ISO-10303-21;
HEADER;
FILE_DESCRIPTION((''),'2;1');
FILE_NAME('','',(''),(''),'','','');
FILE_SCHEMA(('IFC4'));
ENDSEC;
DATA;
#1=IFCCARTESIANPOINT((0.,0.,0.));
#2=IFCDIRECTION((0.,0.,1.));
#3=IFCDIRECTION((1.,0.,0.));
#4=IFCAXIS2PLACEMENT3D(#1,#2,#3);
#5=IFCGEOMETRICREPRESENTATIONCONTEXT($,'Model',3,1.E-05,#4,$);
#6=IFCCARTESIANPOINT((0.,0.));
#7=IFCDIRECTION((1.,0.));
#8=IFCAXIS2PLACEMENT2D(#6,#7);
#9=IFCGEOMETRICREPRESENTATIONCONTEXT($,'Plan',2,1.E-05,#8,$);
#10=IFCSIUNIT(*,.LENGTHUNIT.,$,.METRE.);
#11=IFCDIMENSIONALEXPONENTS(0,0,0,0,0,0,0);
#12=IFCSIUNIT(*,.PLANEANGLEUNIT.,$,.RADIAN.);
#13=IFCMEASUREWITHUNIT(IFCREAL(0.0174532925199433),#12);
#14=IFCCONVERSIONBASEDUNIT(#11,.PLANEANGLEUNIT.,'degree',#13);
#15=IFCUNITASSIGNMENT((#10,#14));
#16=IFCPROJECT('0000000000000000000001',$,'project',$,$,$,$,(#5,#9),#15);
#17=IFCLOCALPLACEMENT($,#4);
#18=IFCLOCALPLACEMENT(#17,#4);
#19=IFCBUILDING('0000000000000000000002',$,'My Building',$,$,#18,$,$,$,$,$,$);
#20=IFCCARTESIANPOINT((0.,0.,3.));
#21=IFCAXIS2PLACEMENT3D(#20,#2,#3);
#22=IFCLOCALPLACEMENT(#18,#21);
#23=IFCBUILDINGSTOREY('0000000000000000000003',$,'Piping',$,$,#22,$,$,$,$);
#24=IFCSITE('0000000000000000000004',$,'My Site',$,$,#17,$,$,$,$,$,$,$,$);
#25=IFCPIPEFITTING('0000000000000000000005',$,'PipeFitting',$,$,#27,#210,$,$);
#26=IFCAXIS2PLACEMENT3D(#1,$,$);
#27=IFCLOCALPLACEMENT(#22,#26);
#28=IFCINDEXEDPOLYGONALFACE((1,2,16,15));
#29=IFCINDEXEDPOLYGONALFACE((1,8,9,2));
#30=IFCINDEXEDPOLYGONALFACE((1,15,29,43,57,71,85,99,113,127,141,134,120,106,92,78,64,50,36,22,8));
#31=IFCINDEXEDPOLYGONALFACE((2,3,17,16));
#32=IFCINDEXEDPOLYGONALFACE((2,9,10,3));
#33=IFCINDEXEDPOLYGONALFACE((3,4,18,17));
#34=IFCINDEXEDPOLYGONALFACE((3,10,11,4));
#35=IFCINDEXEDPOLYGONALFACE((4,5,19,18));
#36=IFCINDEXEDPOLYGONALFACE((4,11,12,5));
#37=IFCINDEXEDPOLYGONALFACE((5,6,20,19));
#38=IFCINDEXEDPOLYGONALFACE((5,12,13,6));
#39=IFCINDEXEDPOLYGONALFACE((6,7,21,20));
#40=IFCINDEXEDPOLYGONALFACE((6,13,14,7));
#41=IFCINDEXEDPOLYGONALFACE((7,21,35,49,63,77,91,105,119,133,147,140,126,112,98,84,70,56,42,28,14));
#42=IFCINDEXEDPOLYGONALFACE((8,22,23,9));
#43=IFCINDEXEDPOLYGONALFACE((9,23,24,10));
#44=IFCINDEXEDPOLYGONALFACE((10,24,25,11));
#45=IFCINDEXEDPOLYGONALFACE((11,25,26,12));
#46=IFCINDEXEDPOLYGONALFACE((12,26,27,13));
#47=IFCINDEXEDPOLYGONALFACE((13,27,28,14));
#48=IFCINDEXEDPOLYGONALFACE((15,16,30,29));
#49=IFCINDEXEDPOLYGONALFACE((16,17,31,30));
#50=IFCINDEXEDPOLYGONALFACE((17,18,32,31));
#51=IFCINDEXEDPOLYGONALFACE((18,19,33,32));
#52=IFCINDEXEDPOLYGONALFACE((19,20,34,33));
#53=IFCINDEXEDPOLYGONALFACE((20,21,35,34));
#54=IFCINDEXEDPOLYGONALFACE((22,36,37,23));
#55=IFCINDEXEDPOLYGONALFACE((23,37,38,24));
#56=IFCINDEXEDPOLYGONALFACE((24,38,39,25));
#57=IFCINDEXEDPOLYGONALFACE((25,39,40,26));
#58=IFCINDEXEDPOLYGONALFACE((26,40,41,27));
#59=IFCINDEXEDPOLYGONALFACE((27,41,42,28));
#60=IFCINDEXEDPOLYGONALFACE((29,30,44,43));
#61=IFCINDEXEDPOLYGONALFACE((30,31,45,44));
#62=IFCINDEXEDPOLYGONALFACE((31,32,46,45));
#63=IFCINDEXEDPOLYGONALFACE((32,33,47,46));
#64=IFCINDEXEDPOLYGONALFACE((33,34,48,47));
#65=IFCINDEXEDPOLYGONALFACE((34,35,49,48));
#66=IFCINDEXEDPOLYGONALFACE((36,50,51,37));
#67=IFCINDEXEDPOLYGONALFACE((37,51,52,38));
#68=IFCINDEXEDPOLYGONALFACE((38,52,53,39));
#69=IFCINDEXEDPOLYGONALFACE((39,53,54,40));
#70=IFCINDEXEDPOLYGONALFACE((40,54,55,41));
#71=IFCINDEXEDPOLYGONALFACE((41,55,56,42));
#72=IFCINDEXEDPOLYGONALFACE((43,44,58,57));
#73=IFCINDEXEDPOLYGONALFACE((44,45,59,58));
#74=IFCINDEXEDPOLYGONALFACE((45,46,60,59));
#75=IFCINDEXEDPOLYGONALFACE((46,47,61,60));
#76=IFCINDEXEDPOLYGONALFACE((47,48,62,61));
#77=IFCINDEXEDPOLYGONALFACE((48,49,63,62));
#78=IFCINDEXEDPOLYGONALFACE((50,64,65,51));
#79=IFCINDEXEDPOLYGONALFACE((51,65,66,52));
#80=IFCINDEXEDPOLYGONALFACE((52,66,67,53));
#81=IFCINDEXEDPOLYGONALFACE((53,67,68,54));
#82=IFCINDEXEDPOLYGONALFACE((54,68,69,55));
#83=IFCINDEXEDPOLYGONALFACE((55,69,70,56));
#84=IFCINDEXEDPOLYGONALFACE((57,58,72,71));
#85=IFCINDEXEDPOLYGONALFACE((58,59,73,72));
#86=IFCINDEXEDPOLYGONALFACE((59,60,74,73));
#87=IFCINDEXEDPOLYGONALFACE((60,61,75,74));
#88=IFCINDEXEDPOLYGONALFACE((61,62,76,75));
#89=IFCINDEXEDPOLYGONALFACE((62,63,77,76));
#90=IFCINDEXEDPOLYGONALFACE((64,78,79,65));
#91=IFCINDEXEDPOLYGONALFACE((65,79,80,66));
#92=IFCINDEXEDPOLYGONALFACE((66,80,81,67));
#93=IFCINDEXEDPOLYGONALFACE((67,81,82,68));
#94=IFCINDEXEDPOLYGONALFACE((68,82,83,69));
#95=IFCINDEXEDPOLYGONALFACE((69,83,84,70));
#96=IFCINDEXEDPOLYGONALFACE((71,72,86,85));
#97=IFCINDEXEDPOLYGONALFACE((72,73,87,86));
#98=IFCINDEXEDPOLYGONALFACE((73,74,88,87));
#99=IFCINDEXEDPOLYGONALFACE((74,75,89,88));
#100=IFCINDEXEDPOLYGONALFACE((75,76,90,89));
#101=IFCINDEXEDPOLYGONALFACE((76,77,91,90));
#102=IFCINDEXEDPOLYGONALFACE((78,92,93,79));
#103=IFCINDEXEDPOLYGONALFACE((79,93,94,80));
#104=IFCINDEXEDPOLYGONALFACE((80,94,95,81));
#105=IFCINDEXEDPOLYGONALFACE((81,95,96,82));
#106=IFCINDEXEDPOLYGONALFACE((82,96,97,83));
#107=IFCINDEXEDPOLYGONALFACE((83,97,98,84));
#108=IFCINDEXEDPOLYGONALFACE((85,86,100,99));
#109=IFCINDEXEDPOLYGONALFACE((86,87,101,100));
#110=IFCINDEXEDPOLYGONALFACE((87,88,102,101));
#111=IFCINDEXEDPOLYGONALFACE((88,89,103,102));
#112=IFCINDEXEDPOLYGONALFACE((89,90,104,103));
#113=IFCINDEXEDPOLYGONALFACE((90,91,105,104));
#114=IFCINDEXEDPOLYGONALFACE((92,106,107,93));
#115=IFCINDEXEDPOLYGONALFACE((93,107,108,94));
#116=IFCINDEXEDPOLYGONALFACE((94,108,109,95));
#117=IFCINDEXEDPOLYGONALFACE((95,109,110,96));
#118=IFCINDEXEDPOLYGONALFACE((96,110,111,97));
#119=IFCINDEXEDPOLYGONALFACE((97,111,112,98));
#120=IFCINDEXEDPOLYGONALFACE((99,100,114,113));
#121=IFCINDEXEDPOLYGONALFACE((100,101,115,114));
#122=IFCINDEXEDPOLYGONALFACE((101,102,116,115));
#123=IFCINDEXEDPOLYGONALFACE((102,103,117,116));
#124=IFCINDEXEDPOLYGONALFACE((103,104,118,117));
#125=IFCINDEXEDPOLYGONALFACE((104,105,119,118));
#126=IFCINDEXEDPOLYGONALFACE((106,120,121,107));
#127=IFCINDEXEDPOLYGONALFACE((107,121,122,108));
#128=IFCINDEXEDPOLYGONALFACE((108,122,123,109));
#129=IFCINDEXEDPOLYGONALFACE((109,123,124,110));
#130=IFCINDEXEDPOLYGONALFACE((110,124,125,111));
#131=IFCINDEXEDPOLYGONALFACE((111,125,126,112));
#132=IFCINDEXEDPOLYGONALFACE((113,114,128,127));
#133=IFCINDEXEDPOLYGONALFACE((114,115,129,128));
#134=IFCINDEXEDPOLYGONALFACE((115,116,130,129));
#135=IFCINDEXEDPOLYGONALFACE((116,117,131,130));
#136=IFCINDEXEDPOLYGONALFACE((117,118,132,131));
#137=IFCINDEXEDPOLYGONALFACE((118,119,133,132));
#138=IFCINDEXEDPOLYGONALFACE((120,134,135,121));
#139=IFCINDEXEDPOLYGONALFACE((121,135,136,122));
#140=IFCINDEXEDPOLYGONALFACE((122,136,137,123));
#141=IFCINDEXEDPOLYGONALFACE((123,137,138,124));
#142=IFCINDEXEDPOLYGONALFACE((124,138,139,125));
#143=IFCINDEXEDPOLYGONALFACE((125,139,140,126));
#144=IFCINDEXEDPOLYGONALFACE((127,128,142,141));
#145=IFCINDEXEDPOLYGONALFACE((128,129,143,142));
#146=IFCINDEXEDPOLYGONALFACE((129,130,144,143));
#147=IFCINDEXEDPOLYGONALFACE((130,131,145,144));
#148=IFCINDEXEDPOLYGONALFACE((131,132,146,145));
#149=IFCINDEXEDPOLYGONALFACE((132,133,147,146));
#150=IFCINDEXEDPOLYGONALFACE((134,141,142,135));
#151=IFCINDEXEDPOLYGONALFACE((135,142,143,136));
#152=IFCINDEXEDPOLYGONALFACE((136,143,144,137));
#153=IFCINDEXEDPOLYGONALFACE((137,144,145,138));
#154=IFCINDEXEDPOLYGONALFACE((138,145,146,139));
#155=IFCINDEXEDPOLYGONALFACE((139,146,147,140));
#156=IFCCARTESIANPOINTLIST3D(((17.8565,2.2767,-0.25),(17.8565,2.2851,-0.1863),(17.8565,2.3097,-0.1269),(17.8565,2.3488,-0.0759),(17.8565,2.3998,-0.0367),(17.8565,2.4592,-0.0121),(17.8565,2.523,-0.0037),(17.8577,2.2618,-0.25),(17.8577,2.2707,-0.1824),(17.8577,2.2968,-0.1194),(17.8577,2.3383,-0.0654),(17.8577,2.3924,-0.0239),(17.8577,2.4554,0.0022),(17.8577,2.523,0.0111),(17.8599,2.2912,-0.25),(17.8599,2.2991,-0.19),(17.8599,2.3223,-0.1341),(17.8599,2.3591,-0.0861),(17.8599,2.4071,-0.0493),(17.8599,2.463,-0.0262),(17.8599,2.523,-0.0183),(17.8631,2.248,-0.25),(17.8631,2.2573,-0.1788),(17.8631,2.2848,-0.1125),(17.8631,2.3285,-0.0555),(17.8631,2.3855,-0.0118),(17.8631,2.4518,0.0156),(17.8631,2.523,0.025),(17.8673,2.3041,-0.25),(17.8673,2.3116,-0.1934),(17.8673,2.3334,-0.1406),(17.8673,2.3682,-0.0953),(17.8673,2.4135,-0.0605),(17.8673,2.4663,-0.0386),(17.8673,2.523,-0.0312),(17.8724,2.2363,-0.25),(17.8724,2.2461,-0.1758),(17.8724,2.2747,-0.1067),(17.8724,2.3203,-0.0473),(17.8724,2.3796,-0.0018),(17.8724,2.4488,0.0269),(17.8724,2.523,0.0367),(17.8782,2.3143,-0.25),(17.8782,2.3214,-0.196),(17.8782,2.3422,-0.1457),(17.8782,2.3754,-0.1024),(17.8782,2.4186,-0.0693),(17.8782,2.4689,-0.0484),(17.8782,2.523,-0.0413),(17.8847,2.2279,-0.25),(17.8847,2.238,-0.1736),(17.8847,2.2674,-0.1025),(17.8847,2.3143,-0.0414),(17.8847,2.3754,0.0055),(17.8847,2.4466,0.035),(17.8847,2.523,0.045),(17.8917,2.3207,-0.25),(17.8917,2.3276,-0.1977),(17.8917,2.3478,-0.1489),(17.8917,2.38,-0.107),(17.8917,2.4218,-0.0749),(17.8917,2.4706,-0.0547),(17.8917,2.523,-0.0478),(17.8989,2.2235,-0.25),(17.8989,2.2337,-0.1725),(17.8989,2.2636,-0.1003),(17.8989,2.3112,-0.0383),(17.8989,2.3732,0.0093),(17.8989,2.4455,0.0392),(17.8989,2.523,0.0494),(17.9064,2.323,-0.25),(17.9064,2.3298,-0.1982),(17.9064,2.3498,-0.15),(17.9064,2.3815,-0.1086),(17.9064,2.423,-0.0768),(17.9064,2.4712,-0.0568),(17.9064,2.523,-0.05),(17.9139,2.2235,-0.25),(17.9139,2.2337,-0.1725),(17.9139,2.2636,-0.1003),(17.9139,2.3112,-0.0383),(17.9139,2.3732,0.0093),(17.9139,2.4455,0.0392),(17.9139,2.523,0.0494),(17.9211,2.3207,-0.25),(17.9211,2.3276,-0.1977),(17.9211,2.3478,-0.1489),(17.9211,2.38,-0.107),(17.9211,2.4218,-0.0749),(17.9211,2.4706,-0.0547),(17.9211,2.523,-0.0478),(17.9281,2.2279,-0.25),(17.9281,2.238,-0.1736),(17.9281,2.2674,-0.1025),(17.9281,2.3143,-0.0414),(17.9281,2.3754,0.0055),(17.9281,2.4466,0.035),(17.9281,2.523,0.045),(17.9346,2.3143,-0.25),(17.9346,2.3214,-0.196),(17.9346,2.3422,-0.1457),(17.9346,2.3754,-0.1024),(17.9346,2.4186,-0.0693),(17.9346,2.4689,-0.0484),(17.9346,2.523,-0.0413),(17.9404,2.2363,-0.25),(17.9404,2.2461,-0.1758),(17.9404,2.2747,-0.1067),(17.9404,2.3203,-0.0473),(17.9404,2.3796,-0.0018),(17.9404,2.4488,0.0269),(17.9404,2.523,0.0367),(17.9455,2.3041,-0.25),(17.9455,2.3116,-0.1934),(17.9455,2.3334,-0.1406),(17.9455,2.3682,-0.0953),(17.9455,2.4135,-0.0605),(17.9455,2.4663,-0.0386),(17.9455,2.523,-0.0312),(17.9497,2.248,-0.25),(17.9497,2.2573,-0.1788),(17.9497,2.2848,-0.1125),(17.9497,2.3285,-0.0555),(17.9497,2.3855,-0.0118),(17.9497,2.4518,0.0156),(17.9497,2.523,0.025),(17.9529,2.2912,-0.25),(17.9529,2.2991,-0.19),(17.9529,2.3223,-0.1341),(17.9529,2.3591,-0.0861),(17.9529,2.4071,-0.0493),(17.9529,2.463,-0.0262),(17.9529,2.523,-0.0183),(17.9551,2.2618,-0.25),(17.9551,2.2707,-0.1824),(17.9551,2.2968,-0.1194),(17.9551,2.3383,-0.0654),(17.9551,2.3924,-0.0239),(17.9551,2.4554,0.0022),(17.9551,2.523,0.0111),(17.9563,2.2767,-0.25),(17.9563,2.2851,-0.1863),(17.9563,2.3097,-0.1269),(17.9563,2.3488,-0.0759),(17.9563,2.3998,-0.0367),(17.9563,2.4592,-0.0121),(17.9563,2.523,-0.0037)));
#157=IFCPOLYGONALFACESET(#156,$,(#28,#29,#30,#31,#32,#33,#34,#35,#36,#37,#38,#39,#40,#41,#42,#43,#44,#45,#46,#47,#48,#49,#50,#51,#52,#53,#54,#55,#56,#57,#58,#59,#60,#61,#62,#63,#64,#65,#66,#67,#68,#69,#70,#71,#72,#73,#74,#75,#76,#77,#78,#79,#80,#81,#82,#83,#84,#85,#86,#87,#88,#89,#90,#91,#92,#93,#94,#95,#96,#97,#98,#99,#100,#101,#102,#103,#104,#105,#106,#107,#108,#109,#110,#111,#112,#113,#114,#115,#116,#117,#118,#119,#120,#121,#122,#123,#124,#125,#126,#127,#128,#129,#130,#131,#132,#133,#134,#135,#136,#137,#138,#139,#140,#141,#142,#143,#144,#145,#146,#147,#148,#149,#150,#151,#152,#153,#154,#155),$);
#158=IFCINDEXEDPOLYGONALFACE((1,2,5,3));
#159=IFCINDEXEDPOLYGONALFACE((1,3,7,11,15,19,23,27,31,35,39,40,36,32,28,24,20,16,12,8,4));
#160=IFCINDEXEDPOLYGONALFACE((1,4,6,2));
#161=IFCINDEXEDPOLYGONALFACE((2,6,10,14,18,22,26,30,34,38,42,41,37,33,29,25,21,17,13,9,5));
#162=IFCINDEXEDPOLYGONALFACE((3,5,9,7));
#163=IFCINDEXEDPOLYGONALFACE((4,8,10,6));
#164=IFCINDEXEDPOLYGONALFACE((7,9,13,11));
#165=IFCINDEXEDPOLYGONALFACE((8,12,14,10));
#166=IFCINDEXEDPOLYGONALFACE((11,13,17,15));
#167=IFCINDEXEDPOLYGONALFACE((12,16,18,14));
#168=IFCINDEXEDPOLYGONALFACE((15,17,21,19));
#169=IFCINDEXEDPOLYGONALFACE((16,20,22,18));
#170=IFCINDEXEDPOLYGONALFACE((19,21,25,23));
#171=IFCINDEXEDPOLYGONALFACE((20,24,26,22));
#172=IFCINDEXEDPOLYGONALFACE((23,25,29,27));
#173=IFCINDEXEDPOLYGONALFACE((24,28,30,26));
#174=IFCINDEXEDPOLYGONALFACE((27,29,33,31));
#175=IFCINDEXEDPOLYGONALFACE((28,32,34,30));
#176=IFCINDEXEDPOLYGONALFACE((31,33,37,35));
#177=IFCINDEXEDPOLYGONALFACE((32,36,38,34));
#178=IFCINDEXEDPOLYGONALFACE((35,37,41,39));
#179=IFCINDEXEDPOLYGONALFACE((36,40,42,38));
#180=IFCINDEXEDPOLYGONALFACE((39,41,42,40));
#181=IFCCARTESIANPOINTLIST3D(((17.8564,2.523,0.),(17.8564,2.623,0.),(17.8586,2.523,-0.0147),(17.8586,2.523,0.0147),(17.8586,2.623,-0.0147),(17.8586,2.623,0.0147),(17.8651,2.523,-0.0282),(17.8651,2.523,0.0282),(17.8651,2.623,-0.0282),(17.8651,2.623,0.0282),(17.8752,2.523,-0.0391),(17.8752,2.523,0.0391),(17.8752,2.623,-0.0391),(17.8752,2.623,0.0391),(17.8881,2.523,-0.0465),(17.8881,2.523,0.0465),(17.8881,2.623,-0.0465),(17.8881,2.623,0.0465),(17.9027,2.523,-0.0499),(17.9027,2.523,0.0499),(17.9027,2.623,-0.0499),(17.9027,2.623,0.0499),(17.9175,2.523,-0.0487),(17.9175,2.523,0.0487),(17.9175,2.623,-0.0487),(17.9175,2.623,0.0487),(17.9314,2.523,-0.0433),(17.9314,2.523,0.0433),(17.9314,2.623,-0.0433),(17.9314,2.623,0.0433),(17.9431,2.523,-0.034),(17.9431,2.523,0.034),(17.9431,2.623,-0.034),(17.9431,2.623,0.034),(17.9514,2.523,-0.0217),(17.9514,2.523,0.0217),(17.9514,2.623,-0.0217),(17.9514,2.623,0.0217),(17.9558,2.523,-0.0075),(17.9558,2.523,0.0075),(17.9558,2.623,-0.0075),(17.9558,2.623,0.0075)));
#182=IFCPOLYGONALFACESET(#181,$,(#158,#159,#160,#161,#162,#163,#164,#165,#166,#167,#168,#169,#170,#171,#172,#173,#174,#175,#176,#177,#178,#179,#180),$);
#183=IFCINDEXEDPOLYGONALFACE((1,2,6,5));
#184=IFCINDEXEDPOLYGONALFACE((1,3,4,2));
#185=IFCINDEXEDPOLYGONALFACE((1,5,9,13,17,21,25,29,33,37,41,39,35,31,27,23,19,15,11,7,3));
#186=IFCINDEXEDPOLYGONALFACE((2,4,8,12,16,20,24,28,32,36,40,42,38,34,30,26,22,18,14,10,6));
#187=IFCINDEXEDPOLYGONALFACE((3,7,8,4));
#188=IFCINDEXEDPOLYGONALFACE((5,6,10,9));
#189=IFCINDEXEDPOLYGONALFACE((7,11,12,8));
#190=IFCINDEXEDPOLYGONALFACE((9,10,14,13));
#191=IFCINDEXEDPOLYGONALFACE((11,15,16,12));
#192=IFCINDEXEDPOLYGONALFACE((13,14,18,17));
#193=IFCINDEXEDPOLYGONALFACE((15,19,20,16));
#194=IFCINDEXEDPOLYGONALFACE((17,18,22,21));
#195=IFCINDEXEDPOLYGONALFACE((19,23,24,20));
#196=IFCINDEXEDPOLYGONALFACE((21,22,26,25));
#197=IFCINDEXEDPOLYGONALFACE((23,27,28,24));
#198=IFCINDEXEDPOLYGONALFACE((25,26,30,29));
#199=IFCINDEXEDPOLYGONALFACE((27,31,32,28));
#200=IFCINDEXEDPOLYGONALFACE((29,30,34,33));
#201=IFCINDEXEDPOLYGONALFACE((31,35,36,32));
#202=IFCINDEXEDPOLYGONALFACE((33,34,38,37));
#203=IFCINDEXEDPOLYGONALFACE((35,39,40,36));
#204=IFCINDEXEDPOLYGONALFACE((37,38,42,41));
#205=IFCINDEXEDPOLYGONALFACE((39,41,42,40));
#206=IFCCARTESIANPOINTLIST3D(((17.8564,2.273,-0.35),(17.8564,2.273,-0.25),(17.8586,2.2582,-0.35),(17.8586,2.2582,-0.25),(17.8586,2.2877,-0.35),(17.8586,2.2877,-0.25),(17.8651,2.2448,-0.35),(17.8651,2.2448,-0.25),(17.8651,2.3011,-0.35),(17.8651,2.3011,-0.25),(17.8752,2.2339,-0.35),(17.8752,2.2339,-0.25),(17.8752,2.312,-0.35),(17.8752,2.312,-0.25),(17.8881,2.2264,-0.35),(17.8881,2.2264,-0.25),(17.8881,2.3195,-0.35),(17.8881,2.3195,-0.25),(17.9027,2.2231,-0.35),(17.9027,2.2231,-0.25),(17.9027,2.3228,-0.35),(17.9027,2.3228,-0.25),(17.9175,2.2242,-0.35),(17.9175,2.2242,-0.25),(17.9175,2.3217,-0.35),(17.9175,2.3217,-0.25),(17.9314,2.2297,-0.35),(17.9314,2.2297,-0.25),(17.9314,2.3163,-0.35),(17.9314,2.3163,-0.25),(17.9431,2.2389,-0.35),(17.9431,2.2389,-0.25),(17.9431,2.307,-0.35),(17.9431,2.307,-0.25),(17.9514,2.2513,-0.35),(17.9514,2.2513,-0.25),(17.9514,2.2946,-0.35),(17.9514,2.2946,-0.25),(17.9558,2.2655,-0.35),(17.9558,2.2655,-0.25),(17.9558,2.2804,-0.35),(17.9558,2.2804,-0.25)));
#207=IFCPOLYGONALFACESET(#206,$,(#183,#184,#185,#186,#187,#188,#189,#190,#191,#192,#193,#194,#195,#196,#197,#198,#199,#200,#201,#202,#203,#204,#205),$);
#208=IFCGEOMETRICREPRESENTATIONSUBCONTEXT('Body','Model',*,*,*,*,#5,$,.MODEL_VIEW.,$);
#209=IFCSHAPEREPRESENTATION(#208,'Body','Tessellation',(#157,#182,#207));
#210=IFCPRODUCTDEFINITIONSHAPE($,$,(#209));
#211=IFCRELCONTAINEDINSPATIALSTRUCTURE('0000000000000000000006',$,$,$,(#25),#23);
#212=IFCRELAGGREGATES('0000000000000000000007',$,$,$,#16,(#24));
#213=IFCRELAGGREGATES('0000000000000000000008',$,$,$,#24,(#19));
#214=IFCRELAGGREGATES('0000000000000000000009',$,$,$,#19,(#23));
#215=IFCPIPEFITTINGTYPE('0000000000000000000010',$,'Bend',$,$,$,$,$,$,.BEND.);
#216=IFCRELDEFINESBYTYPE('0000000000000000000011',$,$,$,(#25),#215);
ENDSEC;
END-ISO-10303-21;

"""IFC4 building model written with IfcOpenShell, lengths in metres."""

from ifc_helpers import new_model, entity, si_unit, converted_unit, frame, origin_with_axes, origin_2d_with_axis, place, context, subcontext, project, spatial, circle, extrude, source, transform, mapped, type_object, type_shapes, element, save


model = new_model("IFC4")

# Units and contexts
model_context = context("Model", 3, precision=1e-05, world=origin_with_axes())
plan_context = context("Plan", 2, precision=1e-05, world=origin_2d_with_axis())
body_context = subcontext(model_context, "Body", "Model", "MODEL_VIEW")
ifc_project = project(units=[si_unit("LENGTHUNIT", "METRE"), converted_unit("PLANEANGLEUNIT", "degree", entity("IfcReal", 0.0174532925199433), si_unit("PLANEANGLEUNIT", "RADIAN"), dimensions=[0, 0, 0, 0, 0, 0, 0])], contexts=[model_context, plan_context])

# Site, building, storey
site_placement = place(None, origin_with_axes())
site = spatial("IfcSite", under=ifc_project, at=site_placement, Name="My Site")
building_placement = place(site_placement, origin_with_axes())
building = spatial("IfcBuilding", under=site, at=building_placement, Name="My Building")
storey_placement = place(building_placement, frame((0.0, 0.0, 3.0), z_axis=(0.0, 0.0, 1.0), x_axis=(1.0, 0.0, 0.0)))
storey = spatial("IfcBuildingStorey", under=building, at=storey_placement, Name="Piping")

# Pipe fitting
pipe_fitting_type = type_object("IfcPipeFittingType", Name="Bend", PredefinedType="BEND")
shared_shape = source(origin_with_axes(), body_context, "Body", "SolidModel", [
    entity("IfcSweptDiskSolid", entity("IfcIndexedPolyCurve", entity("IfcCartesianPointList3D", [[0.0, 0.0, -0.1], [0.0, -0.0732, -0.2768], [0.0, -0.25, -0.35]]), [entity("IfcArcIndex", [1, 2, 3])]), 0.05),
    extrude(circle(Radius=0.05), origin_with_axes(), (0.0, 0.0, -1.0), 0.1),
    extrude(circle(Radius=0.05), frame((0.0, -0.25, -0.35), z_axis=(0.0, -1.0, 0.0), x_axis=(1.0, 0.0, 0.0)), (0.0, 0.0, 1.0), 0.1),
])
type_shapes(pipe_fitting_type, [shared_shape])
for number, where, z_axis, x_axis, name in (
    (1, (17.9064, 2.623, 0.0), (0.0, 1.0, 0.0), (-1.0, 0.0, 0.0), "PipeFitting"),
):
    element("IfcPipeFitting", number, at=place(storey_placement, frame(where, z_axis=z_axis, x_axis=x_axis)), inside=storey, type_object=pipe_fitting_type, Name=name, context=body_context, shape_type="MappedRepresentation", body=[
        mapped(shared_shape, transform((0.0, 0.0, 0.0), x_axis=(1.0, 0.0, 0.0), y_axis=(0.0, 1.0, 0.0), z_axis=(0.0, 0.0, 1.0), scale=1.0)),
    ])

save(model, "model.ifc")
